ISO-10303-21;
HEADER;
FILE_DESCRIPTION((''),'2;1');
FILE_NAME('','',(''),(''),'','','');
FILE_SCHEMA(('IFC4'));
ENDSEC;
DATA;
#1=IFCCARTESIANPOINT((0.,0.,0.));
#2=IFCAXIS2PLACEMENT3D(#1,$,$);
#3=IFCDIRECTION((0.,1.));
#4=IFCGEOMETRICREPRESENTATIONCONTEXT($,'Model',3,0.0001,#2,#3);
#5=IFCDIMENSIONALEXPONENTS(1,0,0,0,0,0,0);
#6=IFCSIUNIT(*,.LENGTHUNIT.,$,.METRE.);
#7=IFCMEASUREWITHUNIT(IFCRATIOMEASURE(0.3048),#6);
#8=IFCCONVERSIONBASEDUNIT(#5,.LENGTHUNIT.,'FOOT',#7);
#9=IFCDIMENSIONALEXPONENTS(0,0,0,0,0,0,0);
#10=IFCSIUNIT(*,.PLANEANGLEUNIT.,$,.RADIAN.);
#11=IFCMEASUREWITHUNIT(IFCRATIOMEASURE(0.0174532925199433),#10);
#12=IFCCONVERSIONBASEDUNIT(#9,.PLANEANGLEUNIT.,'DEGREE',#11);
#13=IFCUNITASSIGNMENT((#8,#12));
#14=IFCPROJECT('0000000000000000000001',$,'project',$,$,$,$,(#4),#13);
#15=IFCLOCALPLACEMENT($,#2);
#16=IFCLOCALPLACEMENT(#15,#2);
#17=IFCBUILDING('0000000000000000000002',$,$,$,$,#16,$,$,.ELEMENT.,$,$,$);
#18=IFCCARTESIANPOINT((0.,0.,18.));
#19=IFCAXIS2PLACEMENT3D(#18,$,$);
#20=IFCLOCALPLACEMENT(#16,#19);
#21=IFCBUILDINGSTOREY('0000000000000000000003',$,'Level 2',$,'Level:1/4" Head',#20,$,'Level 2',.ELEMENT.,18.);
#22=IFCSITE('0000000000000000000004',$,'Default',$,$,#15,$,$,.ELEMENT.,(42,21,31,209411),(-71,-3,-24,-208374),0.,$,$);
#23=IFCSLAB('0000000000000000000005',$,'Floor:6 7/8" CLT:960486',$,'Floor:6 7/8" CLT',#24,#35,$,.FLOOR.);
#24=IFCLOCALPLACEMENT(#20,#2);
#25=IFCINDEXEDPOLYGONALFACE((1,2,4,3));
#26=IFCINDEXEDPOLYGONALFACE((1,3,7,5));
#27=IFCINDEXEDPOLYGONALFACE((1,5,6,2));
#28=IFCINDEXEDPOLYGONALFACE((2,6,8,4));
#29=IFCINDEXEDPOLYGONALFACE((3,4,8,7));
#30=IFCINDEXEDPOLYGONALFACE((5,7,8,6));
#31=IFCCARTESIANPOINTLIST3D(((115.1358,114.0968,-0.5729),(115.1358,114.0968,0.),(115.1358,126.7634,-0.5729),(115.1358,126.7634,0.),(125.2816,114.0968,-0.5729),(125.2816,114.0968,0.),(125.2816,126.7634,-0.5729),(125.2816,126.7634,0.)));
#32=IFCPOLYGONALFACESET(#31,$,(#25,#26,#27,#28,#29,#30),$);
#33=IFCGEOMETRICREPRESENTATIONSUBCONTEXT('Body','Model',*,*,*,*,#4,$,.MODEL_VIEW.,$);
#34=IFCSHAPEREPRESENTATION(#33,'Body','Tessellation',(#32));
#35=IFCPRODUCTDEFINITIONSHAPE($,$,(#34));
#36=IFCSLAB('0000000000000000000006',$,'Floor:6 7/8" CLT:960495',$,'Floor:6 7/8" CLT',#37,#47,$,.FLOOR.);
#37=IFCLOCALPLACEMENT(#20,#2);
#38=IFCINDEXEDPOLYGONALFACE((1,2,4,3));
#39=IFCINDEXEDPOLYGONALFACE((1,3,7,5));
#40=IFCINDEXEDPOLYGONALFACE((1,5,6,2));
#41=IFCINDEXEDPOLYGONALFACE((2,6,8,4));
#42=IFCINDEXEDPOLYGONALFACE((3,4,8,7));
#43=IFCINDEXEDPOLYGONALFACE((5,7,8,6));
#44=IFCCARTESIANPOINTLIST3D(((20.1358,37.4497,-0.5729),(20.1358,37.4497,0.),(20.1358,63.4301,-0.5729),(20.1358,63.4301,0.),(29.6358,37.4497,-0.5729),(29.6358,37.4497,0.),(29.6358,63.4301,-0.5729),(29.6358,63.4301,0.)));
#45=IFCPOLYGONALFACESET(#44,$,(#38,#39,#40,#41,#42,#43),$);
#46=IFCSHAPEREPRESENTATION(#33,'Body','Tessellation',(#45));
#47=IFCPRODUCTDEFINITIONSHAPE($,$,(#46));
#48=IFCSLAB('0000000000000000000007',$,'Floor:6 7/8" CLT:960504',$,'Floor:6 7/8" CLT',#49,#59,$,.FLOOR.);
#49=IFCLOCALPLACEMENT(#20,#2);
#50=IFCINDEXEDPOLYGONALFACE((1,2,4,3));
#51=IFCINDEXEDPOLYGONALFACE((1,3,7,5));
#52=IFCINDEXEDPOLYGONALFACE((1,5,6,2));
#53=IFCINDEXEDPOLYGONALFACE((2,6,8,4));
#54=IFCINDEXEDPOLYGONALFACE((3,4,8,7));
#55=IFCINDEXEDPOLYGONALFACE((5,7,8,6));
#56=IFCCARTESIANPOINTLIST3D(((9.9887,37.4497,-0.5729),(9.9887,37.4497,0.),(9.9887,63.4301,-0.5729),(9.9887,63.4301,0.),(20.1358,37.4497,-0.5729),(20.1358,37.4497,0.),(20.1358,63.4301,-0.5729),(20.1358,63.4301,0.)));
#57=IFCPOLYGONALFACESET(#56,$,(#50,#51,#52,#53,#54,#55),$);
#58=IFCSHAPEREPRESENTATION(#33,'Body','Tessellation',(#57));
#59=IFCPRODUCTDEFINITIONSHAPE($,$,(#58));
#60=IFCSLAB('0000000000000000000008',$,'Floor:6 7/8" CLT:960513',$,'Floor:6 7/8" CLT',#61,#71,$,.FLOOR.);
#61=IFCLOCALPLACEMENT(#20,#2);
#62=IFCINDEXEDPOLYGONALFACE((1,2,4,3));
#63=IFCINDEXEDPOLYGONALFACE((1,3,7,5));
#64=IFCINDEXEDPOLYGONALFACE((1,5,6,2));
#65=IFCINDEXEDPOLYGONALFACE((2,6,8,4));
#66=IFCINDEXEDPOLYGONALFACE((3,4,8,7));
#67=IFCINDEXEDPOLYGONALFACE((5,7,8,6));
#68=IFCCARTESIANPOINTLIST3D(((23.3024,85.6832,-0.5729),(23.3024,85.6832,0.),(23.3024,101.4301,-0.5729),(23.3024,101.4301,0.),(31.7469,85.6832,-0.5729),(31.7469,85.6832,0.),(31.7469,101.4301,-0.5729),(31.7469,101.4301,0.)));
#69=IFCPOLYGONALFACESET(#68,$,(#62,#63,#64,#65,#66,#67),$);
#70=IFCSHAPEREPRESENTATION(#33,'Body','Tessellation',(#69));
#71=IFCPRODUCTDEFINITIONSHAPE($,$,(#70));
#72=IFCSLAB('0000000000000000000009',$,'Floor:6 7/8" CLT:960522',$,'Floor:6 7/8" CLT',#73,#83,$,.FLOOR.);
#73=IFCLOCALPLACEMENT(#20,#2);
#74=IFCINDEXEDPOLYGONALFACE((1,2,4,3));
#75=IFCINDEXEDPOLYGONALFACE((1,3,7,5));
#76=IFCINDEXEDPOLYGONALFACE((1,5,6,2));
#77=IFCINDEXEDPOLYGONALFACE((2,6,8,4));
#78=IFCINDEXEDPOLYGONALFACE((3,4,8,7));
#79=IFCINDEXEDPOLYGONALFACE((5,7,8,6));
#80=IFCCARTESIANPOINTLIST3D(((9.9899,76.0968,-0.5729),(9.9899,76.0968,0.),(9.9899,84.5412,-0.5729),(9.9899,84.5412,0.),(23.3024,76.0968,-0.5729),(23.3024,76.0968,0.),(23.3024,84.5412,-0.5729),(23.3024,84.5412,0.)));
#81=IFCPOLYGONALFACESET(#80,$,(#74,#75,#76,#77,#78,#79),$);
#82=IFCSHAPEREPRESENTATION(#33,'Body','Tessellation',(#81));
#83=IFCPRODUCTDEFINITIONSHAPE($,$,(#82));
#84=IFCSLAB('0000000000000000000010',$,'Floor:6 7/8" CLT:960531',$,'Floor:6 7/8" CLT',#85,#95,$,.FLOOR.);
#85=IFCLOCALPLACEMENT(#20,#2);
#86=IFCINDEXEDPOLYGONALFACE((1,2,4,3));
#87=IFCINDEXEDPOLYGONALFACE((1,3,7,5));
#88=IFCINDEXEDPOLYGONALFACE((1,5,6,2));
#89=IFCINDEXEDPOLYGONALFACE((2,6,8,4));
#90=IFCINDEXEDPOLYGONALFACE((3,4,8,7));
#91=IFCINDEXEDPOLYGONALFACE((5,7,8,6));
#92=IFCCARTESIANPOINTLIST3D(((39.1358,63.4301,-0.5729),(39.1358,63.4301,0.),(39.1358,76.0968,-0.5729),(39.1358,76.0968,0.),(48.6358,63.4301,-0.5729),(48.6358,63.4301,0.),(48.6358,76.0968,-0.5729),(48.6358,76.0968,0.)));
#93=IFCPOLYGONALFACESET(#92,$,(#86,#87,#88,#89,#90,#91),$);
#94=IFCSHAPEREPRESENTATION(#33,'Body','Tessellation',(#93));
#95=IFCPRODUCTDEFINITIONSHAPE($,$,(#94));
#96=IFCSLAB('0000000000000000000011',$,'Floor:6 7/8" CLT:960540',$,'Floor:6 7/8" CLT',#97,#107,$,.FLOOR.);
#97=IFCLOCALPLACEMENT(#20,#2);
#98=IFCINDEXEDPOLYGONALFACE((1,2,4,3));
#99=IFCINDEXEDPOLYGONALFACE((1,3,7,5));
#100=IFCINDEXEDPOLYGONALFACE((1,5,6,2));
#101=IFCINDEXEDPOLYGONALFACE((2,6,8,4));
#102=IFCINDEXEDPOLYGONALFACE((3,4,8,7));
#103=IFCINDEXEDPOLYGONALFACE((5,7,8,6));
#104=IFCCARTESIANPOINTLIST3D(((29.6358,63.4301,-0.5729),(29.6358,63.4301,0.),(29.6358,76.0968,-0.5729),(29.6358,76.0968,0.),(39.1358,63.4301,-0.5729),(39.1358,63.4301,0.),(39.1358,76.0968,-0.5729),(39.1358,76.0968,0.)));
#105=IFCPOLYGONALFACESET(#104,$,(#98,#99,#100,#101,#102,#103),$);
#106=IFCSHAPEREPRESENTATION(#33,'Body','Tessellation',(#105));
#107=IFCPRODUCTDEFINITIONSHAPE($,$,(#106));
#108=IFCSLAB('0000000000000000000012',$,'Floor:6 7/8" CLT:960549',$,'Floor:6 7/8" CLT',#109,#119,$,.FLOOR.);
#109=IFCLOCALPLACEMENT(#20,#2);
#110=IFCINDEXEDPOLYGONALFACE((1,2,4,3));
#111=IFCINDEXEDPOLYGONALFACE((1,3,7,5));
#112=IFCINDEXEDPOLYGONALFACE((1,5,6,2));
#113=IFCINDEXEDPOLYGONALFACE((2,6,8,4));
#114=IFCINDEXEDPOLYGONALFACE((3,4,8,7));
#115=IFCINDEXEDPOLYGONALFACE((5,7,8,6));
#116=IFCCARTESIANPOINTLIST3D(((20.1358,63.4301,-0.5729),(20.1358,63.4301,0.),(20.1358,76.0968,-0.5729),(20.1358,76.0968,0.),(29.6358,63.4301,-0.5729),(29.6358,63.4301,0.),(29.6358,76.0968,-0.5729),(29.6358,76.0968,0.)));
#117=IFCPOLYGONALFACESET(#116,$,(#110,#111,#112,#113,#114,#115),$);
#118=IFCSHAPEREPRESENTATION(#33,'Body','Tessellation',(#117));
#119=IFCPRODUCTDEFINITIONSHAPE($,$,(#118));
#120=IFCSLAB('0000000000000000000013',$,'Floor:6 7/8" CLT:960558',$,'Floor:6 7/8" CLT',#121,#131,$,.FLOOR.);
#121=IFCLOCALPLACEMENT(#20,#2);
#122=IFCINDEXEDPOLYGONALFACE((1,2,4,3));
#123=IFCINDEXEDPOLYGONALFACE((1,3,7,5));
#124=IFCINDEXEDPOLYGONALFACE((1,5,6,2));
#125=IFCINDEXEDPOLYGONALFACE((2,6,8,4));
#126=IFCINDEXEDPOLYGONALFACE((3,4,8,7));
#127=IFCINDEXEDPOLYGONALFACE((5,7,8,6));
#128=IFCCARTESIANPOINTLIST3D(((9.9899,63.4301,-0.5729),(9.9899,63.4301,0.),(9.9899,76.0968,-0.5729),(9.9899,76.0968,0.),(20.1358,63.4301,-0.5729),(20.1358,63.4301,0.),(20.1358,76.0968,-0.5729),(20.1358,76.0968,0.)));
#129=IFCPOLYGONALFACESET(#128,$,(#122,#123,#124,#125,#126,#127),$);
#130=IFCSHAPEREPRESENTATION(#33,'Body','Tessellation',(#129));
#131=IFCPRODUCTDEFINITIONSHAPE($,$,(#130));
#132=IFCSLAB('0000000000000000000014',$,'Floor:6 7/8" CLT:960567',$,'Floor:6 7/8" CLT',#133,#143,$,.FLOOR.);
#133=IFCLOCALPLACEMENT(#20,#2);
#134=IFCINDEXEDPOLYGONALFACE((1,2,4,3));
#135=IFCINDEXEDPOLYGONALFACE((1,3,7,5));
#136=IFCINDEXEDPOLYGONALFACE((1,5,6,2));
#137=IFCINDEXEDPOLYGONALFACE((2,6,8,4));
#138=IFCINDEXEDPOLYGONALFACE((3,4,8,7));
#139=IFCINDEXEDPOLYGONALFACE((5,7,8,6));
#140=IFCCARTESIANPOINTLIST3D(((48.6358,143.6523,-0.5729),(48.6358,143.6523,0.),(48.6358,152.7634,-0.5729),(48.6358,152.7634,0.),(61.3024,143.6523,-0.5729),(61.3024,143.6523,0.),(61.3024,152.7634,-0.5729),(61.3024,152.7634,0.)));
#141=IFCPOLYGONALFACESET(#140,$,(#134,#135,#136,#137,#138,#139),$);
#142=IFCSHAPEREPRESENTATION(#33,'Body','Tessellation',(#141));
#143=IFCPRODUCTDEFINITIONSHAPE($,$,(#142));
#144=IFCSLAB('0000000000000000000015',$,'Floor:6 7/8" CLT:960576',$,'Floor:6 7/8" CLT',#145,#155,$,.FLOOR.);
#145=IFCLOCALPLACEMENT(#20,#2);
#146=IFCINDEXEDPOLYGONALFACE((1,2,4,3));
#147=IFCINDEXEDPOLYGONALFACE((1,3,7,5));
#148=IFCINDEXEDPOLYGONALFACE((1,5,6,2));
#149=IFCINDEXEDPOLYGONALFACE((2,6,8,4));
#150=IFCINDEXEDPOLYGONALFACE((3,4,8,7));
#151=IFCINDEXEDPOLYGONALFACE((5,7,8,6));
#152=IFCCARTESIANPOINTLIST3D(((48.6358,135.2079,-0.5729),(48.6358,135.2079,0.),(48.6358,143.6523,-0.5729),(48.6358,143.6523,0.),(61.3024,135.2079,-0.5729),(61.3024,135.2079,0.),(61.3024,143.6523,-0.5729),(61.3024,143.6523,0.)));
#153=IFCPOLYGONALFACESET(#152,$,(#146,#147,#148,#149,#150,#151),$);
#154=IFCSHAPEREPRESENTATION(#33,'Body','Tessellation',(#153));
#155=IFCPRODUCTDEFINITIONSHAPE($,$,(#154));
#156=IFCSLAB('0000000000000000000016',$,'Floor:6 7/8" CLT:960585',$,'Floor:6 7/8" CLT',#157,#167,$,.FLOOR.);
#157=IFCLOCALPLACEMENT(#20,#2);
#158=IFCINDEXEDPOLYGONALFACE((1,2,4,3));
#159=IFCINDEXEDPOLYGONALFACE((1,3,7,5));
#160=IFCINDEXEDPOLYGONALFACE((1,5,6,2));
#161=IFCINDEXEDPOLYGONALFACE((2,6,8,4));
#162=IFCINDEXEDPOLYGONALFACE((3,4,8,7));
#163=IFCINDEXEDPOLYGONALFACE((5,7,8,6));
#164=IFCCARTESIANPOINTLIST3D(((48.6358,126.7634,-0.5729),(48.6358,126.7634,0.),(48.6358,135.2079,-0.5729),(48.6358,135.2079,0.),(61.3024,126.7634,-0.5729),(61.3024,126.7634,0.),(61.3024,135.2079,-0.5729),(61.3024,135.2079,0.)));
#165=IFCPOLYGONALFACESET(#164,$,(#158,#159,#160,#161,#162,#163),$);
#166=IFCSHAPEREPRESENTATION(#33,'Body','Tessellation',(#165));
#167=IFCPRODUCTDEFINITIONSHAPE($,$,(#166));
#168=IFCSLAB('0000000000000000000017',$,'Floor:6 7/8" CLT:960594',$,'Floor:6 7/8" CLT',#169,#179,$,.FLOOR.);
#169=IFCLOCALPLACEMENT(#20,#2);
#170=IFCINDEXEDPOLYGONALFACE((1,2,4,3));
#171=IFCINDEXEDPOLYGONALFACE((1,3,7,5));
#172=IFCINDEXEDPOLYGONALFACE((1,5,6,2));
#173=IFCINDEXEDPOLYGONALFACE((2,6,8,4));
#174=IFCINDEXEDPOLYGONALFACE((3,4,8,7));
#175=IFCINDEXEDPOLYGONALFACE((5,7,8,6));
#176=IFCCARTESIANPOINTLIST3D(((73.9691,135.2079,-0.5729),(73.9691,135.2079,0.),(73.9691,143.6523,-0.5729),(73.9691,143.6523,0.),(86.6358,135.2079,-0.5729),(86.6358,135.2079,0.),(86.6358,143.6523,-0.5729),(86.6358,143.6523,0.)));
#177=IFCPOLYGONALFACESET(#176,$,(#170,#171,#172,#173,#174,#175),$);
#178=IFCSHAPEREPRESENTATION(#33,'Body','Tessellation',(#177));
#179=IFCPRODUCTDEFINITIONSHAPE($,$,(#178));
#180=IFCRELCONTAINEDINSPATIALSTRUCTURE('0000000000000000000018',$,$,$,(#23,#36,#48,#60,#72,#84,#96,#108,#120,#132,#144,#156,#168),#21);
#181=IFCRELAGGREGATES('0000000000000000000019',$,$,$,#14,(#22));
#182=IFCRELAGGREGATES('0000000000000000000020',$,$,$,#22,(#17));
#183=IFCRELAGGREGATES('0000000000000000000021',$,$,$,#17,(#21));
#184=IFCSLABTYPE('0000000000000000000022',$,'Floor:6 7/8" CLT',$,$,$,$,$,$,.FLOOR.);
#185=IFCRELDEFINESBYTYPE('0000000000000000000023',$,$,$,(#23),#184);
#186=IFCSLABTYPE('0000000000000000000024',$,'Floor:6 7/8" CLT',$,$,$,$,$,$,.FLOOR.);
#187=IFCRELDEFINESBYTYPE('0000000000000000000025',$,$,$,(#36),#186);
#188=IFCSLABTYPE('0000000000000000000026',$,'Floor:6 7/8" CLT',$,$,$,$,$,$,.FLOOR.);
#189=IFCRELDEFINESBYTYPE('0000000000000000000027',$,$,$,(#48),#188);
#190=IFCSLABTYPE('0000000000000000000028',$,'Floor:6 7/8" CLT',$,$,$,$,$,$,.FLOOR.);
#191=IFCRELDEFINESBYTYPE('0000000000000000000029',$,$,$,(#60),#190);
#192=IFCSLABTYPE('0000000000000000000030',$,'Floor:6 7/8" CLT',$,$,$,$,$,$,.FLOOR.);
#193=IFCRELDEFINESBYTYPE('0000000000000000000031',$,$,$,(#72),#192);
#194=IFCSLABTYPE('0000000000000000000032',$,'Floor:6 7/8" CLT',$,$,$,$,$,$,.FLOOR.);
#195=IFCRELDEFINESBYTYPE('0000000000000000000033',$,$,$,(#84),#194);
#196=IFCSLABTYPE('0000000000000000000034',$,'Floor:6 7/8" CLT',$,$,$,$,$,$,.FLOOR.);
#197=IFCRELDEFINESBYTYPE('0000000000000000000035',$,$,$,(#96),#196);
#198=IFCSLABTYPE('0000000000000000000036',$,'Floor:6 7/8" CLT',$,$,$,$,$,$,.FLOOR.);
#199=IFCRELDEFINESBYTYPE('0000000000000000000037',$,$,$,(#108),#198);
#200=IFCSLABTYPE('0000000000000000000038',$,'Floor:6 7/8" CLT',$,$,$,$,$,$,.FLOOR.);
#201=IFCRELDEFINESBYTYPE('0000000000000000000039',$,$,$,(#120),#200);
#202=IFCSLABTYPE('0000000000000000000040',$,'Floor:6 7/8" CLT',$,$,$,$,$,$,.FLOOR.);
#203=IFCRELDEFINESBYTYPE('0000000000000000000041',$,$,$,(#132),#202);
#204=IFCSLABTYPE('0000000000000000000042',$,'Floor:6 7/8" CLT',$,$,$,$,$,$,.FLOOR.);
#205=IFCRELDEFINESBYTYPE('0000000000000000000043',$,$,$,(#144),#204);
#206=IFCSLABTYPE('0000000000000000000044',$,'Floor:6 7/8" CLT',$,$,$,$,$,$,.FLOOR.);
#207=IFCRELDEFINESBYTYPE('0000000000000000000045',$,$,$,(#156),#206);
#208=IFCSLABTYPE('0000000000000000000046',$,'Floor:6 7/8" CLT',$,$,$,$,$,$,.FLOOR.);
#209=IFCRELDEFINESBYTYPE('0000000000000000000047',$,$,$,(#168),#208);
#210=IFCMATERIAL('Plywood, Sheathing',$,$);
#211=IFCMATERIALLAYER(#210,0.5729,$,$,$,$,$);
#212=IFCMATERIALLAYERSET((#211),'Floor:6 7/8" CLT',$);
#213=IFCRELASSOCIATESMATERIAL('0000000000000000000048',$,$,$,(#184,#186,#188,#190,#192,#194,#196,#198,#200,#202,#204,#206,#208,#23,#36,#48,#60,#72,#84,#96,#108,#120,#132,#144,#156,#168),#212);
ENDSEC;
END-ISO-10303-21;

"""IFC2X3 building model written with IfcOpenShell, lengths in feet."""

from ifc_helpers import new_model, entity, si_unit, converted_unit, direction, frame, frame_2d, origin, place, context, subcontext, project, spatial, rectangle, extrude, material, layer, layer_set, layer_usage, type_object, element, save


model = new_model("IFC2X3")

# Units and contexts
model_context = context("Model", 3, precision=0.0001, world=origin(), true_north=direction((0.0, 1.0)))
body_context = subcontext(model_context, "Body", "Model", "MODEL_VIEW")
ifc_project = project(units=[converted_unit("LENGTHUNIT", "FOOT", entity("IfcRatioMeasure", 0.3048), si_unit("LENGTHUNIT", "METRE"), dimensions=[1, 0, 0, 0, 0, 0, 0]), converted_unit("PLANEANGLEUNIT", "DEGREE", entity("IfcRatioMeasure", 0.0174532925199433), si_unit("PLANEANGLEUNIT", "RADIAN"), dimensions=[0, 0, 0, 0, 0, 0, 0])], contexts=[model_context])

# Site, building, storey
site_placement = place(None, origin())
site = spatial("IfcSite", under=ifc_project, at=site_placement, Name="Default", CompositionType="ELEMENT", RefLatitude=(42, 21, 31, 209411), RefLongitude=(-71, -3, -24, -208374), RefElevation=0.0)
building_placement = place(site_placement, origin())
building = spatial("IfcBuilding", under=site, at=building_placement, CompositionType="ELEMENT")
storey_placement = place(building_placement, frame((0.0, 0.0, 18.0)))
storey = spatial("IfcBuildingStorey", under=building, at=storey_placement, Name="Level 2", ObjectType="Level:1/4\" Head", LongName="Level 2", CompositionType="ELEMENT", Elevation=18.0)

# Slabs
ifc_material = material(Name="Plywood, Sheathing")
ifc_layer = layer(ifc_material, 0.5729)
ifc_layer_set = layer_set([ifc_layer], Name="Floor:6 7/8\" CLT")
ifc_layer_usage_1 = layer_usage(ifc_layer_set, "AXIS3", "POSITIVE", 0.0)
slab_type_1 = type_object("IfcSlabType", Name="Floor:6 7/8\" CLT", PredefinedType="FLOOR", material=ifc_layer_set)
slab_1_placement = place(storey_placement, origin())
element("IfcSlab", 1, at=slab_1_placement, inside=storey, type_object=slab_type_1, material=ifc_layer_usage_1, Name="Floor:6 7/8\" CLT:960486", ObjectType="Floor:6 7/8\" CLT", PredefinedType="FLOOR", context=body_context, shape_type="SweptSolid", body=[
    extrude(rectangle(XDim=12.6667, YDim=10.1458, at=frame_2d((0.0, 0.0), x_axis=(1.0, 0.0))), frame((120.2087, 120.4301, 0.0), z_axis=(0.0, 0.0, -1.0), x_axis=(0.0, 1.0, 0.0)), (0.0, 0.0, 1.0), 0.5729),
])
ifc_layer_usage_2 = layer_usage(ifc_layer_set, "AXIS3", "POSITIVE", 0.0)
slab_type_2 = type_object("IfcSlabType", Name="Floor:6 7/8\" CLT", PredefinedType="FLOOR", material=ifc_layer_set)
slab_2_placement = place(storey_placement, origin())
element("IfcSlab", 2, at=slab_2_placement, inside=storey, type_object=slab_type_2, material=ifc_layer_usage_2, Name="Floor:6 7/8\" CLT:960495", ObjectType="Floor:6 7/8\" CLT", PredefinedType="FLOOR", context=body_context, shape_type="SweptSolid", body=[
    extrude(rectangle(XDim=25.9804, YDim=9.5, at=frame_2d((0.0, 0.0), x_axis=(1.0, 0.0))), frame((24.8858, 50.4399, 0.0), z_axis=(0.0, 0.0, -1.0), x_axis=(0.0, 1.0, 0.0)), (0.0, 0.0, 1.0), 0.5729),
])
ifc_layer_usage_3 = layer_usage(ifc_layer_set, "AXIS3", "POSITIVE", 0.0)
slab_type_3 = type_object("IfcSlabType", Name="Floor:6 7/8\" CLT", PredefinedType="FLOOR", material=ifc_layer_set)
slab_3_placement = place(storey_placement, origin())
element("IfcSlab", 3, at=slab_3_placement, inside=storey, type_object=slab_type_3, material=ifc_layer_usage_3, Name="Floor:6 7/8\" CLT:960504", ObjectType="Floor:6 7/8\" CLT", PredefinedType="FLOOR", context=body_context, shape_type="SweptSolid", body=[
    extrude(rectangle(XDim=25.9804, YDim=10.1471, at=frame_2d((0.0, 0.0), x_axis=(1.0, 0.0))), frame((15.0622, 50.4399, 0.0), z_axis=(0.0, 0.0, -1.0), x_axis=(0.0, 1.0, 0.0)), (0.0, 0.0, 1.0), 0.5729),
])
ifc_layer_usage_4 = layer_usage(ifc_layer_set, "AXIS3", "POSITIVE", 0.0)
slab_type_4 = type_object("IfcSlabType", Name="Floor:6 7/8\" CLT", PredefinedType="FLOOR", material=ifc_layer_set)
slab_4_placement = place(storey_placement, origin())
element("IfcSlab", 4, at=slab_4_placement, inside=storey, type_object=slab_type_4, material=ifc_layer_usage_4, Name="Floor:6 7/8\" CLT:960513", ObjectType="Floor:6 7/8\" CLT", PredefinedType="FLOOR", context=body_context, shape_type="SweptSolid", body=[
    extrude(rectangle(XDim=15.7469, YDim=8.4444, at=frame_2d((0.0, 0.0), x_axis=(1.0, 0.0))), frame((27.5247, 93.5566, 0.0), z_axis=(0.0, 0.0, -1.0), x_axis=(0.0, 1.0, 0.0)), (0.0, 0.0, 1.0), 0.5729),
])
ifc_layer_usage_5 = layer_usage(ifc_layer_set, "AXIS3", "POSITIVE", 0.0)
slab_type_5 = type_object("IfcSlabType", Name="Floor:6 7/8\" CLT", PredefinedType="FLOOR", material=ifc_layer_set)
slab_5_placement = place(storey_placement, origin())
element("IfcSlab", 5, at=slab_5_placement, inside=storey, type_object=slab_type_5, material=ifc_layer_usage_5, Name="Floor:6 7/8\" CLT:960522", ObjectType="Floor:6 7/8\" CLT", PredefinedType="FLOOR", context=body_context, shape_type="SweptSolid", body=[
    extrude(rectangle(XDim=8.4444, YDim=13.3125, at=frame_2d((0.0, 0.0), x_axis=(1.0, 0.0))), frame((16.6462, 80.319, 0.0), z_axis=(0.0, 0.0, -1.0), x_axis=(0.0, 1.0, 0.0)), (0.0, 0.0, 1.0), 0.5729),
])
ifc_layer_usage_6 = layer_usage(ifc_layer_set, "AXIS3", "POSITIVE", 0.0)
slab_type_6 = type_object("IfcSlabType", Name="Floor:6 7/8\" CLT", PredefinedType="FLOOR", material=ifc_layer_set)
slab_6_placement = place(storey_placement, origin())
element("IfcSlab", 6, at=slab_6_placement, inside=storey, type_object=slab_type_6, material=ifc_layer_usage_6, Name="Floor:6 7/8\" CLT:960531", ObjectType="Floor:6 7/8\" CLT", PredefinedType="FLOOR", context=body_context, shape_type="SweptSolid", body=[
    extrude(rectangle(XDim=12.6667, YDim=9.5, at=frame_2d((0.0, 0.0), x_axis=(1.0, 0.0))), frame((43.8858, 69.7634, 0.0), z_axis=(0.0, 0.0, -1.0), x_axis=(0.0, 1.0, 0.0)), (0.0, 0.0, 1.0), 0.5729),
])
ifc_layer_usage_7 = layer_usage(ifc_layer_set, "AXIS3", "POSITIVE", 0.0)
slab_type_7 = type_object("IfcSlabType", Name="Floor:6 7/8\" CLT", PredefinedType="FLOOR", material=ifc_layer_set)
slab_7_placement = place(storey_placement, origin())
element("IfcSlab", 7, at=slab_7_placement, inside=storey, type_object=slab_type_7, material=ifc_layer_usage_7, Name="Floor:6 7/8\" CLT:960540", ObjectType="Floor:6 7/8\" CLT", PredefinedType="FLOOR", context=body_context, shape_type="SweptSolid", body=[
    extrude(rectangle(XDim=12.6667, YDim=9.5, at=frame_2d((0.0, 0.0), x_axis=(1.0, 0.0))), frame((34.3858, 69.7634, 0.0), z_axis=(0.0, 0.0, -1.0), x_axis=(0.0, 1.0, 0.0)), (0.0, 0.0, 1.0), 0.5729),
])
ifc_layer_usage_8 = layer_usage(ifc_layer_set, "AXIS3", "POSITIVE", 0.0)
slab_type_8 = type_object("IfcSlabType", Name="Floor:6 7/8\" CLT", PredefinedType="FLOOR", material=ifc_layer_set)
slab_8_placement = place(storey_placement, origin())
element("IfcSlab", 8, at=slab_8_placement, inside=storey, type_object=slab_type_8, material=ifc_layer_usage_8, Name="Floor:6 7/8\" CLT:960549", ObjectType="Floor:6 7/8\" CLT", PredefinedType="FLOOR", context=body_context, shape_type="SweptSolid", body=[
    extrude(rectangle(XDim=12.6667, YDim=9.5, at=frame_2d((0.0, 0.0), x_axis=(1.0, 0.0))), frame((24.8858, 69.7634, 0.0), z_axis=(0.0, 0.0, -1.0), x_axis=(0.0, 1.0, 0.0)), (0.0, 0.0, 1.0), 0.5729),
])
ifc_layer_usage_9 = layer_usage(ifc_layer_set, "AXIS3", "POSITIVE", 0.0)
slab_type_9 = type_object("IfcSlabType", Name="Floor:6 7/8\" CLT", PredefinedType="FLOOR", material=ifc_layer_set)
slab_9_placement = place(storey_placement, origin())
element("IfcSlab", 9, at=slab_9_placement, inside=storey, type_object=slab_type_9, material=ifc_layer_usage_9, Name="Floor:6 7/8\" CLT:960558", ObjectType="Floor:6 7/8\" CLT", PredefinedType="FLOOR", context=body_context, shape_type="SweptSolid", body=[
    extrude(rectangle(XDim=12.6667, YDim=10.1458, at=frame_2d((0.0, 0.0), x_axis=(1.0, 0.0))), frame((15.0629, 69.7634, 0.0), z_axis=(0.0, 0.0, -1.0), x_axis=(0.0, 1.0, 0.0)), (0.0, 0.0, 1.0), 0.5729),
])
ifc_layer_usage_10 = layer_usage(ifc_layer_set, "AXIS3", "POSITIVE", 0.0)
slab_type_10 = type_object("IfcSlabType", Name="Floor:6 7/8\" CLT", PredefinedType="FLOOR", material=ifc_layer_set)
slab_10_placement = place(storey_placement, origin())
element("IfcSlab", 10, at=slab_10_placement, inside=storey, type_object=slab_type_10, material=ifc_layer_usage_10, Name="Floor:6 7/8\" CLT:960567", ObjectType="Floor:6 7/8\" CLT", PredefinedType="FLOOR", context=body_context, shape_type="SweptSolid", body=[
    extrude(rectangle(XDim=9.1111, YDim=12.6667, at=frame_2d((0.0, 0.0), x_axis=(1.0, 0.0))), frame((54.9691, 148.2079, 0.0), z_axis=(0.0, 0.0, -1.0), x_axis=(0.0, 1.0, 0.0)), (0.0, 0.0, 1.0), 0.5729),
])
ifc_layer_usage_11 = layer_usage(ifc_layer_set, "AXIS3", "POSITIVE", 0.0)
slab_type_11 = type_object("IfcSlabType", Name="Floor:6 7/8\" CLT", PredefinedType="FLOOR", material=ifc_layer_set)
slab_11_placement = place(storey_placement, origin())
element("IfcSlab", 11, at=slab_11_placement, inside=storey, type_object=slab_type_11, material=ifc_layer_usage_11, Name="Floor:6 7/8\" CLT:960576", ObjectType="Floor:6 7/8\" CLT", PredefinedType="FLOOR", context=body_context, shape_type="SweptSolid", body=[
    extrude(rectangle(XDim=8.4444, YDim=12.6667, at=frame_2d((0.0, 0.0), x_axis=(1.0, 0.0))), frame((54.9691, 139.4301, 0.0), z_axis=(0.0, 0.0, -1.0), x_axis=(0.0, 1.0, 0.0)), (0.0, 0.0, 1.0), 0.5729),
])
ifc_layer_usage_12 = layer_usage(ifc_layer_set, "AXIS3", "POSITIVE", 0.0)
slab_type_12 = type_object("IfcSlabType", Name="Floor:6 7/8\" CLT", PredefinedType="FLOOR", material=ifc_layer_set)
slab_12_placement = place(storey_placement, origin())
element("IfcSlab", 12, at=slab_12_placement, inside=storey, type_object=slab_type_12, material=ifc_layer_usage_12, Name="Floor:6 7/8\" CLT:960585", ObjectType="Floor:6 7/8\" CLT", PredefinedType="FLOOR", context=body_context, shape_type="SweptSolid", body=[
    extrude(rectangle(XDim=8.4444, YDim=12.6667, at=frame_2d((0.0, 0.0), x_axis=(1.0, 0.0))), frame((54.9691, 130.9856, 0.0), z_axis=(0.0, 0.0, -1.0), x_axis=(0.0, 1.0, 0.0)), (0.0, 0.0, 1.0), 0.5729),
])
ifc_layer_usage_13 = layer_usage(ifc_layer_set, "AXIS3", "POSITIVE", 0.0)
slab_type_13 = type_object("IfcSlabType", Name="Floor:6 7/8\" CLT", PredefinedType="FLOOR", material=ifc_layer_set)
slab_13_placement = place(storey_placement, origin())
element("IfcSlab", 13, at=slab_13_placement, inside=storey, type_object=slab_type_13, material=ifc_layer_usage_13, Name="Floor:6 7/8\" CLT:960594", ObjectType="Floor:6 7/8\" CLT", PredefinedType="FLOOR", context=body_context, shape_type="SweptSolid", body=[
    extrude(rectangle(XDim=8.4444, YDim=12.6667, at=frame_2d((0.0, 0.0), x_axis=(1.0, 0.0))), frame((80.3024, 139.4301, 0.0), z_axis=(0.0, 0.0, -1.0), x_axis=(0.0, 1.0, 0.0)), (0.0, 0.0, 1.0), 0.5729),
])

save(model, "model.ifc")
